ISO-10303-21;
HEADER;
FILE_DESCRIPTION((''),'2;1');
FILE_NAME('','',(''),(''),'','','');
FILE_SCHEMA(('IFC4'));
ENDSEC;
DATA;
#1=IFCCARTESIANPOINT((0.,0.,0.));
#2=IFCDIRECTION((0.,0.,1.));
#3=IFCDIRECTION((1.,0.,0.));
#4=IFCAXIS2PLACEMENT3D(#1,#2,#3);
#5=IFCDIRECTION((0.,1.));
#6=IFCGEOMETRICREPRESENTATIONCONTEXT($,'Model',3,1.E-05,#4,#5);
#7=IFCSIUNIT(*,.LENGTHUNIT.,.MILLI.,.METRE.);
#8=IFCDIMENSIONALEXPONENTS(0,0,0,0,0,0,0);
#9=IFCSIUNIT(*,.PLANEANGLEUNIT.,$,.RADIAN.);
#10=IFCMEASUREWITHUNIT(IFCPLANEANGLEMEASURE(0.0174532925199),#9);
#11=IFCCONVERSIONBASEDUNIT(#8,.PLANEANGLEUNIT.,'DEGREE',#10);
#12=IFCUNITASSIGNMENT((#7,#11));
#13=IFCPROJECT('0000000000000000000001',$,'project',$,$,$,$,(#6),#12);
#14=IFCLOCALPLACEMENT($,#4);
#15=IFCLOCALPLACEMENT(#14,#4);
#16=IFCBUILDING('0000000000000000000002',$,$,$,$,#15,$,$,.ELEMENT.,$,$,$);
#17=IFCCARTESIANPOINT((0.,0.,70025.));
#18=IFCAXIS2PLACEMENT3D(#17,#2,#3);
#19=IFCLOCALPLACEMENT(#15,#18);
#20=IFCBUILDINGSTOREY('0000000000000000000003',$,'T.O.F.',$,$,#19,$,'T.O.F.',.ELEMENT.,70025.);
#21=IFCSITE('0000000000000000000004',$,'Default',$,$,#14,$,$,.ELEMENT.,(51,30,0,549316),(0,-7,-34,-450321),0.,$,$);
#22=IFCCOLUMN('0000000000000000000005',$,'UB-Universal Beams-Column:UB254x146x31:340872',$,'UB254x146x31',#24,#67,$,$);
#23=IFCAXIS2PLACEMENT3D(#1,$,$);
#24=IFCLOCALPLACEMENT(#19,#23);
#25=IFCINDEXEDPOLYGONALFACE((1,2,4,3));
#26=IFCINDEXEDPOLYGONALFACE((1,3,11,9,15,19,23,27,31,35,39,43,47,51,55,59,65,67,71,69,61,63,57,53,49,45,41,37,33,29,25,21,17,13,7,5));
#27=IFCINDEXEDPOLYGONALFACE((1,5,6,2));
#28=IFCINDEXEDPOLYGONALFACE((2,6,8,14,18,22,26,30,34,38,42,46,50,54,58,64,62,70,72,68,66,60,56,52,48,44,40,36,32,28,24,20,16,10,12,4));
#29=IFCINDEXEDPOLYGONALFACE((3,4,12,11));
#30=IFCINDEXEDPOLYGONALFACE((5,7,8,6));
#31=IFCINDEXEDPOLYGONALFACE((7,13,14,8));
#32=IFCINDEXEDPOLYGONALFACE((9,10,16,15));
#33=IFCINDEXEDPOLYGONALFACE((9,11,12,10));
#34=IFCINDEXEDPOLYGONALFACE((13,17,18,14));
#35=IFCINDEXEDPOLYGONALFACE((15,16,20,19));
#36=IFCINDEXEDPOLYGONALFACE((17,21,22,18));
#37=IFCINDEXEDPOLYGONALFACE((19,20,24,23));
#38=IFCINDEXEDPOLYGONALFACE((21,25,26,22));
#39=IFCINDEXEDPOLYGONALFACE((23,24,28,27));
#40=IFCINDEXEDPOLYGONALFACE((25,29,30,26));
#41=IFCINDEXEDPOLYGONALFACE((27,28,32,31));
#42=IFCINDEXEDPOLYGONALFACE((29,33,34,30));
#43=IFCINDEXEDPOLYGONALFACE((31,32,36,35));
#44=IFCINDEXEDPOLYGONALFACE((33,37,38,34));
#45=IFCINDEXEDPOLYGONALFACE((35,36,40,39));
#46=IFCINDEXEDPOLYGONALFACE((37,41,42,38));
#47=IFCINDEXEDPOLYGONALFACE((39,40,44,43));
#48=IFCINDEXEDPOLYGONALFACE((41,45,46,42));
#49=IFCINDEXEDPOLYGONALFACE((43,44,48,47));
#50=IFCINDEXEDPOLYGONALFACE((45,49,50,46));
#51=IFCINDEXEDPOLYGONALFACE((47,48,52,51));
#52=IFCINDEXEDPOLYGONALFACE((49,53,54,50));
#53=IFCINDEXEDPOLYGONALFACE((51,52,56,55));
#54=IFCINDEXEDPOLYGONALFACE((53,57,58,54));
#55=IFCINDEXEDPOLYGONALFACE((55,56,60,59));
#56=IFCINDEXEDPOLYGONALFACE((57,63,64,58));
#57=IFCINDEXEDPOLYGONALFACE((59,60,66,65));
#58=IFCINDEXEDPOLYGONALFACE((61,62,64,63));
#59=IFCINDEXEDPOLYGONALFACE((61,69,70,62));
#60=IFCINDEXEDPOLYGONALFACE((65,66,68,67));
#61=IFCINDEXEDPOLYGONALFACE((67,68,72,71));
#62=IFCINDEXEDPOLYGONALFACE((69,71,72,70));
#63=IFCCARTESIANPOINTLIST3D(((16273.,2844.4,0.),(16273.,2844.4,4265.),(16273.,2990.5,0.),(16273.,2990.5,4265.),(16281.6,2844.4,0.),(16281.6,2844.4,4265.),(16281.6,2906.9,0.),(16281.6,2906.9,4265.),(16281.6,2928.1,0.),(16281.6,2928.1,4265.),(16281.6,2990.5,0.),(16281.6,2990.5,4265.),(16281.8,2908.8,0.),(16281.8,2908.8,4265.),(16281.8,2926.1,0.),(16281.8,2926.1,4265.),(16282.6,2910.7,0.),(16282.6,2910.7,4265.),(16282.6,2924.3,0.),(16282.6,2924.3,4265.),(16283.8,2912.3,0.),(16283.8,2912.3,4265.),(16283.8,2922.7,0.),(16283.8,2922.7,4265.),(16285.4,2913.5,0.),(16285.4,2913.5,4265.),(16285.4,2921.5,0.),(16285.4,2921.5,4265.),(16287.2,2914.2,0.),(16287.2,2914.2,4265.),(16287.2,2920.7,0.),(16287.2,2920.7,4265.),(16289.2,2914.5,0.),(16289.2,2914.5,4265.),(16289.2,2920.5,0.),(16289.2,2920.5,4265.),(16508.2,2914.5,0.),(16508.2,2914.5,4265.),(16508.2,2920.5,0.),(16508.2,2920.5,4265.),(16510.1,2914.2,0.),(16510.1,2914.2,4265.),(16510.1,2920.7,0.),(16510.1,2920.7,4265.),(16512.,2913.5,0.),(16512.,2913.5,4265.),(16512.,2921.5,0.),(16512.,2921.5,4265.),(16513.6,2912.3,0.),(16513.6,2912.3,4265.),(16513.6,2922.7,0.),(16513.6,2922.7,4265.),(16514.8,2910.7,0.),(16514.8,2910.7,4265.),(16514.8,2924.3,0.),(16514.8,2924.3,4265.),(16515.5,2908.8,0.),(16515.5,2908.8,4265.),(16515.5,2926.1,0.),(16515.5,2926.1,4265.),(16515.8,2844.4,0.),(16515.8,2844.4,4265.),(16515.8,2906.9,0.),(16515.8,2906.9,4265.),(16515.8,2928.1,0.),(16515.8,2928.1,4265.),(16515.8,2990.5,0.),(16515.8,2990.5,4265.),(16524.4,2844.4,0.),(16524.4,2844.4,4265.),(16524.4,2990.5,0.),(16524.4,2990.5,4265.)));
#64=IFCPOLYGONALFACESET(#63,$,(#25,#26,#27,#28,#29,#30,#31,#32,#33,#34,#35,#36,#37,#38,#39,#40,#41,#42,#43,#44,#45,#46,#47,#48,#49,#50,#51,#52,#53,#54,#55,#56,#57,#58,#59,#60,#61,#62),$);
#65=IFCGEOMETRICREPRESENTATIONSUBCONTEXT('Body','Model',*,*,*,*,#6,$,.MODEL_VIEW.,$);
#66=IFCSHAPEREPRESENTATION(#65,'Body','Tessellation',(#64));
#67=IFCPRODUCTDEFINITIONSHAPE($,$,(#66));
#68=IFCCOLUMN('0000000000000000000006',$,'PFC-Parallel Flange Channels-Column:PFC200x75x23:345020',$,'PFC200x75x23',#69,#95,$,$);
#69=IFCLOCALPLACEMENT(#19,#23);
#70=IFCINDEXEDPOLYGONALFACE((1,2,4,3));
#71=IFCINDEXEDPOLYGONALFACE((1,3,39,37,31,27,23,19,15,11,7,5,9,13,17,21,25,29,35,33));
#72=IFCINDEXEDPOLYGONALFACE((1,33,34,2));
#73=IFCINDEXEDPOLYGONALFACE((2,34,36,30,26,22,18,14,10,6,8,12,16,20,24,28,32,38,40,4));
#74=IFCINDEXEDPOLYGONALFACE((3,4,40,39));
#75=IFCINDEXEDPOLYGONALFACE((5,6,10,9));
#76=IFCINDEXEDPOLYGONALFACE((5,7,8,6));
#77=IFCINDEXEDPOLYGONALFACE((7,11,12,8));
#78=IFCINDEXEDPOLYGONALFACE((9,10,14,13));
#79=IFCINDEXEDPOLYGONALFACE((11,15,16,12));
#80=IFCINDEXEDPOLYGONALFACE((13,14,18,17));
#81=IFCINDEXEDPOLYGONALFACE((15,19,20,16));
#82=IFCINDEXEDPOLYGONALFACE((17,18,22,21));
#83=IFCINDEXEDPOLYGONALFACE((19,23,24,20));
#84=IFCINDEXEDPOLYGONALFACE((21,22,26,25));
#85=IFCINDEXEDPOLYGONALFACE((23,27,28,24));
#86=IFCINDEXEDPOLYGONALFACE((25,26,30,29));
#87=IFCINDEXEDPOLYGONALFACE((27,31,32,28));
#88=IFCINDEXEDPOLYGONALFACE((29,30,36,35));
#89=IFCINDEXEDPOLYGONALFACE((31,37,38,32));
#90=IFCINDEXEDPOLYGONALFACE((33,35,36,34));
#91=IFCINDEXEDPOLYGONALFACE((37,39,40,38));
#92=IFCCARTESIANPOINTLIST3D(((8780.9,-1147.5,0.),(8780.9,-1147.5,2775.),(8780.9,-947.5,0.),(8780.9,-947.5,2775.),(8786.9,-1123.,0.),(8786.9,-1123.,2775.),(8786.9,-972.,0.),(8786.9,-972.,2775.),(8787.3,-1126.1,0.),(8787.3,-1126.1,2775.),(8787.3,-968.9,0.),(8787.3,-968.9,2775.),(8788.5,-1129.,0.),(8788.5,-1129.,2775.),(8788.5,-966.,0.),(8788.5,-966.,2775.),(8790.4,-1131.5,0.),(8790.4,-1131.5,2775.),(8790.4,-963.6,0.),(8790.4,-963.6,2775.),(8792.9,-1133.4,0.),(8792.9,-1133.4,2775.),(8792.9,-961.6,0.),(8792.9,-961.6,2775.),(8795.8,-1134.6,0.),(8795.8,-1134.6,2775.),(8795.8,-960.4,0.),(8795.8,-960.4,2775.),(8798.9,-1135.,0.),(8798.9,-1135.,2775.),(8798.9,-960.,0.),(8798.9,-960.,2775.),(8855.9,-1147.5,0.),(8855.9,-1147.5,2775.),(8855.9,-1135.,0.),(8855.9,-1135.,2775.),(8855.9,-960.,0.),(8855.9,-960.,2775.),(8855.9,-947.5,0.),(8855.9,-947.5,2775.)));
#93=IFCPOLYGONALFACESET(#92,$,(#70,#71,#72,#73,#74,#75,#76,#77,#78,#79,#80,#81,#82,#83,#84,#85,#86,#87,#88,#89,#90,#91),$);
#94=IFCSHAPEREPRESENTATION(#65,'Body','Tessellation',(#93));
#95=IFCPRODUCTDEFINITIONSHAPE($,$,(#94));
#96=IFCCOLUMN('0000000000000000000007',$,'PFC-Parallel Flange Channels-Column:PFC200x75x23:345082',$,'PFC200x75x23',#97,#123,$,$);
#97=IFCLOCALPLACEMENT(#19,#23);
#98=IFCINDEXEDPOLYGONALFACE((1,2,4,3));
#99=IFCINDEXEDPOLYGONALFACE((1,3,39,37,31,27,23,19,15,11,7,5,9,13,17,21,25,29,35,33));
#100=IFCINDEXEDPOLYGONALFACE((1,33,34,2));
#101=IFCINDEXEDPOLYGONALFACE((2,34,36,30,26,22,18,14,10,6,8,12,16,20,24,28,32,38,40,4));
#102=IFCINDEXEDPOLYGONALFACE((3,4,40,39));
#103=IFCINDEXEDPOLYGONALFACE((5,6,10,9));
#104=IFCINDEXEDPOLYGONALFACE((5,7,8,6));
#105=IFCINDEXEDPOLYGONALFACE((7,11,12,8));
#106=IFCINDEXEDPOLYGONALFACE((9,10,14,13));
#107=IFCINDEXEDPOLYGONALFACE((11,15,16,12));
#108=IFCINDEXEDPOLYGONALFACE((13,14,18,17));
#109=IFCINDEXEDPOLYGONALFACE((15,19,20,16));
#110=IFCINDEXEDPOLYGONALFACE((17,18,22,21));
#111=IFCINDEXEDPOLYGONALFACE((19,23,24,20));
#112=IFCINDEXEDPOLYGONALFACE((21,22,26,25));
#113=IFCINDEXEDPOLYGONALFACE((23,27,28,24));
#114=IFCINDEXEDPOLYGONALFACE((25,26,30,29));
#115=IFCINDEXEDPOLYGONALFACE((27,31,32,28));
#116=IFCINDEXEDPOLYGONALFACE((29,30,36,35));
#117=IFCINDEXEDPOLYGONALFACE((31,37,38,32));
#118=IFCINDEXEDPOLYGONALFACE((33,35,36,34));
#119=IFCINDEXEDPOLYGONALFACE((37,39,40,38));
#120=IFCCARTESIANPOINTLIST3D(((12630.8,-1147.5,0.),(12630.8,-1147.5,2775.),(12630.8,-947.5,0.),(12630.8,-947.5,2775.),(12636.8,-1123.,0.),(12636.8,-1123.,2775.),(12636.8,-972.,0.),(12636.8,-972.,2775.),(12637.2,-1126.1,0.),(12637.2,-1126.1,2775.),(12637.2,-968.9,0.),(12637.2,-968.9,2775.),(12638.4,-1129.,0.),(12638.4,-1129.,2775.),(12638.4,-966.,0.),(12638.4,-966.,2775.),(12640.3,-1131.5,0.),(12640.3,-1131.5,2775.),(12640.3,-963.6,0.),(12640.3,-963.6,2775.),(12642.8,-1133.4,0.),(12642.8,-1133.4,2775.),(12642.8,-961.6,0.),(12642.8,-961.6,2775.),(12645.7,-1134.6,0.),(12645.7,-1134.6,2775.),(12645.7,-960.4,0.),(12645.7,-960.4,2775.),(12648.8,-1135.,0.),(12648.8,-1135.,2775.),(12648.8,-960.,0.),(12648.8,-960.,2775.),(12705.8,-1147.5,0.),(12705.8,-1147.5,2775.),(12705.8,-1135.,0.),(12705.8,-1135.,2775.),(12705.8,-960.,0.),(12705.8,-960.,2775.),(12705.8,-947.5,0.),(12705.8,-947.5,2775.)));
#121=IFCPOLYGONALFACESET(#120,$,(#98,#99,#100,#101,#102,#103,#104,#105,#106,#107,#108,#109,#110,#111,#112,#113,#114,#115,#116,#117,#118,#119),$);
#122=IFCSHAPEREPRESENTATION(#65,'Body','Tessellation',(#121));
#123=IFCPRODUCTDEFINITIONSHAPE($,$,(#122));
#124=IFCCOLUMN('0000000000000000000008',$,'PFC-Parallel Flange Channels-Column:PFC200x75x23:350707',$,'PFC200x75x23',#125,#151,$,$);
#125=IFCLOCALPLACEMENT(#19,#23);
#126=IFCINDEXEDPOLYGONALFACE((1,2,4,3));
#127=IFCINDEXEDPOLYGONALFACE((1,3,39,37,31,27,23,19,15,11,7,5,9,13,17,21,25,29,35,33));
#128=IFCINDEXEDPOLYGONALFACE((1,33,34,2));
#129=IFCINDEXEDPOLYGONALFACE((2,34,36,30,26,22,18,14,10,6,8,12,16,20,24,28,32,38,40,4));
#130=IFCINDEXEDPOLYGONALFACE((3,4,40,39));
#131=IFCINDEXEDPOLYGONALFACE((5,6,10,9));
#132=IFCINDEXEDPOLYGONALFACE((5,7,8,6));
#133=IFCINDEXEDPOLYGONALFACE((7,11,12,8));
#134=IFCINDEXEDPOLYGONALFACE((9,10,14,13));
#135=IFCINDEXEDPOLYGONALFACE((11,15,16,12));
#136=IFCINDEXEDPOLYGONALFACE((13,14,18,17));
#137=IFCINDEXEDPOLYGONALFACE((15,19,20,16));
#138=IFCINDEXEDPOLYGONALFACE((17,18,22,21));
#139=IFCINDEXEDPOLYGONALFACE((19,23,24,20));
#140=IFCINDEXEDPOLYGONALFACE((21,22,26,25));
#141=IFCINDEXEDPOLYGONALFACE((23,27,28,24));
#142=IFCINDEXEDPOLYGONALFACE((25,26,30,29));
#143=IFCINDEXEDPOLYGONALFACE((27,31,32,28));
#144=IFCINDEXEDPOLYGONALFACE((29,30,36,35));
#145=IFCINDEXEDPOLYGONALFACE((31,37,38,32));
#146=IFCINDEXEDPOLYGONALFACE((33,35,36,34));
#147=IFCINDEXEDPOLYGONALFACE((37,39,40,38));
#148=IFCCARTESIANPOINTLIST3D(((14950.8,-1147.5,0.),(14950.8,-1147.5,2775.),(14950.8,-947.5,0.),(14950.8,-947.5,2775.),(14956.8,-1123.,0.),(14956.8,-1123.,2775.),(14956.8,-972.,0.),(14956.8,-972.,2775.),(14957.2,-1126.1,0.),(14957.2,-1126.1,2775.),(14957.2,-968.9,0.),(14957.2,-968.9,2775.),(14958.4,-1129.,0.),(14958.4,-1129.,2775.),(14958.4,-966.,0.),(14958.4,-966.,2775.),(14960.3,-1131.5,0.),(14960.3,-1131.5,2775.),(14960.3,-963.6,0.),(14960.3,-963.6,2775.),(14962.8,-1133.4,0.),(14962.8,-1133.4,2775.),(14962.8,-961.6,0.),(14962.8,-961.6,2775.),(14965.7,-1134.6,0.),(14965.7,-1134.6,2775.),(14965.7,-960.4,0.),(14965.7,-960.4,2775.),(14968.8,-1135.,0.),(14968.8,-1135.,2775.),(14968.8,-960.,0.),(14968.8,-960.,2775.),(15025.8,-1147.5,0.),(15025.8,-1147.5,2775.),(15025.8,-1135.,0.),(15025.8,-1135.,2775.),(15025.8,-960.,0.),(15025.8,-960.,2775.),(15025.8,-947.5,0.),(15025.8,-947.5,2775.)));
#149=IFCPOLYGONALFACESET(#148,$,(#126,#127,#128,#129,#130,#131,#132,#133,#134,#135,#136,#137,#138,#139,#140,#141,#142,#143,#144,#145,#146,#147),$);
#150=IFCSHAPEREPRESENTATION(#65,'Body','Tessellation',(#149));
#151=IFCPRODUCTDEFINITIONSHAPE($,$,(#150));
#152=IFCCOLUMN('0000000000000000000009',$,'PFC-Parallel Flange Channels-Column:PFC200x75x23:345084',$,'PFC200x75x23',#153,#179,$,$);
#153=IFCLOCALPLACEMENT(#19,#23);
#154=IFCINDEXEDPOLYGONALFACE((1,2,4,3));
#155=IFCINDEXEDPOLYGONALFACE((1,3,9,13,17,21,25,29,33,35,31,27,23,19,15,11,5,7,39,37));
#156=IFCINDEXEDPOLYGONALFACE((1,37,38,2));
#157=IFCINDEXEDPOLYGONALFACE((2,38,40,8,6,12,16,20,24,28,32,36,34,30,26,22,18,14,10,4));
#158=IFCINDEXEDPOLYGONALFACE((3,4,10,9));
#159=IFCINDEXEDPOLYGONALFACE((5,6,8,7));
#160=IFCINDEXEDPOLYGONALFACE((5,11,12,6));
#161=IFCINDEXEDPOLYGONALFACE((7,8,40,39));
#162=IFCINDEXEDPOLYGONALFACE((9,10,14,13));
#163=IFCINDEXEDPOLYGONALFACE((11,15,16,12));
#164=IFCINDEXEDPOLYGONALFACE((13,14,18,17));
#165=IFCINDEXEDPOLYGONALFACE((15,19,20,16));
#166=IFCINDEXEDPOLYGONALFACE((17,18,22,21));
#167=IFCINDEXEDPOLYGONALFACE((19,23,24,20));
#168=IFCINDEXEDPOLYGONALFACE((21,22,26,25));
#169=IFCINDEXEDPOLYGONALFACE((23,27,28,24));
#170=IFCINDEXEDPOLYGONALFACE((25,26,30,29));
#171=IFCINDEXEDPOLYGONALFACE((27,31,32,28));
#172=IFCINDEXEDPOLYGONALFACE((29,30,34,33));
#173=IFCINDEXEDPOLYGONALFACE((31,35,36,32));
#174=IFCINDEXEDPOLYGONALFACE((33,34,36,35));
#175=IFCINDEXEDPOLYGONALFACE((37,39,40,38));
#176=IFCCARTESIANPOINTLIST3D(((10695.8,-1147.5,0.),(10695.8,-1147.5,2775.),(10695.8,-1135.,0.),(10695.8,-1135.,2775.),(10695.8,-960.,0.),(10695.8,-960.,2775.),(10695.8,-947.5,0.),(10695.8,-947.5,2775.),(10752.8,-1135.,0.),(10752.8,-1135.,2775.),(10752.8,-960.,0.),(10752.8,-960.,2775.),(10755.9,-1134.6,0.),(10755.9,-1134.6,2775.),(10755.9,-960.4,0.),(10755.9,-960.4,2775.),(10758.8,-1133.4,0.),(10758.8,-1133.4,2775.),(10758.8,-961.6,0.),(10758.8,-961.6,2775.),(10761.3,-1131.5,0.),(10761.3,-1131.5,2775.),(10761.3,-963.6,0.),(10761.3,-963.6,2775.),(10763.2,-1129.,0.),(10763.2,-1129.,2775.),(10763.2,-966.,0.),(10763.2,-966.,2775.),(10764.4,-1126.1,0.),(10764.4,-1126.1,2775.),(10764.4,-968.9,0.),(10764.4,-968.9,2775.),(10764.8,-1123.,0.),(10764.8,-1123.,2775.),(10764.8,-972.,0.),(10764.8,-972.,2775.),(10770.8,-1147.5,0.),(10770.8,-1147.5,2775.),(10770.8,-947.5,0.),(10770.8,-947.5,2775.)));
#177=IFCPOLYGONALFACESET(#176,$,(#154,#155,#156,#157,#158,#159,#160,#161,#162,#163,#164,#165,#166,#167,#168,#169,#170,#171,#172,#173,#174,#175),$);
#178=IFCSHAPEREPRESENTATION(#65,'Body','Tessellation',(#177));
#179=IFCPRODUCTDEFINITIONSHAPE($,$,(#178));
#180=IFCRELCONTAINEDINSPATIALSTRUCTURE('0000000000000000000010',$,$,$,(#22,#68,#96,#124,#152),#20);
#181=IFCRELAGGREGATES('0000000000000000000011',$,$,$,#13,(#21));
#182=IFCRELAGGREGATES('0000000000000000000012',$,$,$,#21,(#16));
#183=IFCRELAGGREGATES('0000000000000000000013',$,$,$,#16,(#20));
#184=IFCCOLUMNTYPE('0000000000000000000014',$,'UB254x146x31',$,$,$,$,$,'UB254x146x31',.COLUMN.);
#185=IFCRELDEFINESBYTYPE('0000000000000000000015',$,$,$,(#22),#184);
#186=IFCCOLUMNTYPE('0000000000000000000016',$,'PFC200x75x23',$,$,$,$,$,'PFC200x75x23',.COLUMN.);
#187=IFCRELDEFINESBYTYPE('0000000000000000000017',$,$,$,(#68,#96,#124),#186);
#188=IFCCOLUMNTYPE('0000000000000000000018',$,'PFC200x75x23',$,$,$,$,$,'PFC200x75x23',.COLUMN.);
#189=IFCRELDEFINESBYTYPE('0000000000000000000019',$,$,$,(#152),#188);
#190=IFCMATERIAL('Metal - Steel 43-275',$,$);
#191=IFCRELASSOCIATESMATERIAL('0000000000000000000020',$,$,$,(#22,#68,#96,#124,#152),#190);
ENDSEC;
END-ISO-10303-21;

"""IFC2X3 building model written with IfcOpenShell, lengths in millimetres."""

from ifc_helpers import new_model, entity, si_unit, converted_unit, point, direction, frame, frame_2d, origin_with_axes, place, context, subcontext, project, spatial, polyline, circle_curve, parameter, trimmed, segment, composite_curve, outline, extrude, material, type_object, element, save


model = new_model("IFC2X3")

# Units and contexts
model_context = context("Model", 3, precision=1e-05, world=origin_with_axes(), true_north=direction((0.0, 1.0)))
body_context = subcontext(model_context, "Body", "Model", "MODEL_VIEW")
ifc_project = project(units=[si_unit("LENGTHUNIT", "METRE", prefix="MILLI"), converted_unit("PLANEANGLEUNIT", "DEGREE", entity("IfcPlaneAngleMeasure", 0.0174532925199), si_unit("PLANEANGLEUNIT", "RADIAN"), dimensions=[0, 0, 0, 0, 0, 0, 0])], contexts=[model_context])

# Site, building, storey
site_placement = place(None, origin_with_axes())
site = spatial("IfcSite", under=ifc_project, at=site_placement, Name="Default", CompositionType="ELEMENT", RefLatitude=(51, 30, 0, 549316), RefLongitude=(0, -7, -34, -450321), RefElevation=0.0)
building_placement = place(site_placement, origin_with_axes())
building = spatial("IfcBuilding", under=site, at=building_placement, CompositionType="ELEMENT")
storey_placement = place(building_placement, frame((0.0, 0.0, 70025.0), z_axis=(0.0, 0.0, 1.0), x_axis=(1.0, 0.0, 0.0)))
storey = spatial("IfcBuildingStorey", under=building, at=storey_placement, Name="T.O.F.", LongName="T.O.F.", CompositionType="ELEMENT", Elevation=70025.0)

# Columns
ifc_material_1 = material(Name="Metal - Steel 43-275")
column_type_1 = type_object("IfcColumnType", Name="UB254x146x31", ElementType="UB254x146x31", PredefinedType="COLUMN")
column_1_placement = place(storey_placement, frame((16398.7, 2917.5, 0.0), z_axis=(0.0, 0.0, 1.0), x_axis=(-1.0, 0.0, 0.0)))
element("IfcColumn", 1, at=column_1_placement, inside=storey, type_object=column_type_1, material=ifc_material_1, Name="UB-Universal Beams-Column:UB254x146x31:340872", ObjectType="UB254x146x31", context=body_context, shape_type="SweptSolid", body=[
    extrude(outline(composite_curve([segment(polyline([(117.1, -73.0), (125.7, -73.0), (125.7, 73.0), (117.1, 73.0), (117.1, 10.6)]), True, "CONTINUOUS"), segment(trimmed(circle_curve(frame_2d((109.5, 10.6), x_axis=(0.0, -1.0)), 7.6), [point((117.1, 10.6)), parameter(90.0)], [point((109.5, 3.0)), parameter(0.0)], False, "CARTESIAN"), True, "CONTINUOUS"), segment(polyline([(109.5, 3.0), (-109.5, 3.0)]), True, "CONTINUOUS"), segment(trimmed(circle_curve(frame_2d((-109.5, 10.6), x_axis=(-1.0, 0.0)), 7.6), [point((-109.5, 3.0)), parameter(90.0)], [point((-117.1, 10.6)), parameter(0.0)], False, "CARTESIAN"), True, "CONTINUOUS"), segment(polyline([(-117.1, 10.6), (-117.1, 73.0), (-125.7, 73.0), (-125.7, -73.0), (-117.1, -73.0), (-117.1, -10.6)]), True, "CONTINUOUS"), segment(trimmed(circle_curve(frame_2d((-109.5, -10.6), x_axis=(0.0, 1.0)), 7.6), [point((-117.1, -10.6)), parameter(90.0)], [point((-109.5, -3.0)), parameter(0.0)], False, "CARTESIAN"), True, "CONTINUOUS"), segment(polyline([(-109.5, -3.0), (109.5, -3.0)]), True, "CONTINUOUS"), segment(trimmed(circle_curve(frame_2d((109.5, -10.6), x_axis=(1.0, 0.0)), 7.6), [point((109.5, -3.0)), parameter(90.0)], [point((117.1, -10.6)), parameter(0.0)], False, "CARTESIAN"), True, "CONTINUOUS"), segment(polyline([(117.1, -10.6), (117.1, -73.0)]), True, "CONTINUOUS")], self_intersect=False)), origin_with_axes(), (0.0, 0.0, 1.0), 4265.0),
])
column_type_2 = type_object("IfcColumnType", Name="PFC200x75x23", ElementType="PFC200x75x23", PredefinedType="COLUMN")
for number, where, z_axis, x_axis, name in (
    (2, (8815.7, -1047.5, 0.0), (0.0, 0.0, 1.0), (0.0, -1.0, 0.0), "PFC-Parallel Flange Channels-Column:PFC200x75x23:345020"),
    (3, (12665.6, -1047.5, 0.0), (0.0, 0.0, 1.0), (0.0, -1.0, 0.0), "PFC-Parallel Flange Channels-Column:PFC200x75x23:345082"),
    (4, (14985.6, -1047.5, 0.0), (0.0, 0.0, 1.0), (0.0, -1.0, 0.0), "PFC-Parallel Flange Channels-Column:PFC200x75x23:350707"),
):
    element("IfcColumn", number, at=place(storey_placement, frame(where, z_axis=z_axis, x_axis=x_axis)), inside=storey, type_object=column_type_2, material=ifc_material_1, Name=name, ObjectType="PFC200x75x23", context=body_context, shape_type="SweptSolid", body=[
        extrude(outline(composite_curve([segment(polyline([(-100.0, -34.8), (100.0, -34.8), (100.0, 40.2), (87.5, 40.2), (87.5, -16.8)]), True, "CONTINUOUS"), segment(trimmed(circle_curve(frame_2d((75.5, -16.8), x_axis=(0.0, -1.0)), 12.0), [point((87.5, -16.8)), parameter(90.0)], [point((75.5, -28.8)), parameter(0.0)], False, "CARTESIAN"), True, "CONTINUOUS"), segment(polyline([(75.5, -28.8), (-75.5, -28.8)]), True, "CONTINUOUS"), segment(trimmed(circle_curve(frame_2d((-75.5, -16.8), x_axis=(-1.0, 0.0)), 12.0), [point((-75.5, -28.8)), parameter(90.0)], [point((-87.5, -16.8)), parameter(0.0)], False, "CARTESIAN"), True, "CONTINUOUS"), segment(polyline([(-87.5, -16.8), (-87.5, 40.2), (-100.0, 40.2), (-100.0, -34.8)]), True, "CONTINUOUS")], self_intersect=False)), origin_with_axes(), (0.0, 0.0, 1.0), 2775.0),
    ])
column_type_3 = type_object("IfcColumnType", Name="PFC200x75x23", ElementType="PFC200x75x23", PredefinedType="COLUMN")
for number, where, z_axis, x_axis, name in (
    (5, (10736.0, -1047.5, 0.0), (0.0, 0.0, 1.0), (0.0, 1.0, 0.0), "PFC-Parallel Flange Channels-Column:PFC200x75x23:345084"),
):
    element("IfcColumn", number, at=place(storey_placement, frame(where, z_axis=z_axis, x_axis=x_axis)), inside=storey, type_object=column_type_3, material=ifc_material_1, Name=name, ObjectType="PFC200x75x23", context=body_context, shape_type="SweptSolid", body=[
        extrude(outline(composite_curve([segment(polyline([(-100.0, -34.8), (100.0, -34.8), (100.0, 40.2), (87.5, 40.2), (87.5, -16.8)]), True, "CONTINUOUS"), segment(trimmed(circle_curve(frame_2d((75.5, -16.8), x_axis=(0.0, -1.0)), 12.0), [point((87.5, -16.8)), parameter(90.0)], [point((75.5, -28.8)), parameter(0.0)], False, "CARTESIAN"), True, "CONTINUOUS"), segment(polyline([(75.5, -28.8), (-75.5, -28.8)]), True, "CONTINUOUS"), segment(trimmed(circle_curve(frame_2d((-75.5, -16.8), x_axis=(-1.0, 0.0)), 12.0), [point((-75.5, -28.8)), parameter(90.0)], [point((-87.5, -16.8)), parameter(0.0)], False, "CARTESIAN"), True, "CONTINUOUS"), segment(polyline([(-87.5, -16.8), (-87.5, 40.2), (-100.0, 40.2), (-100.0, -34.8)]), True, "CONTINUOUS")], self_intersect=False)), origin_with_axes(), (0.0, 0.0, 1.0), 2775.0),
    ])

save(model, "model.ifc")
